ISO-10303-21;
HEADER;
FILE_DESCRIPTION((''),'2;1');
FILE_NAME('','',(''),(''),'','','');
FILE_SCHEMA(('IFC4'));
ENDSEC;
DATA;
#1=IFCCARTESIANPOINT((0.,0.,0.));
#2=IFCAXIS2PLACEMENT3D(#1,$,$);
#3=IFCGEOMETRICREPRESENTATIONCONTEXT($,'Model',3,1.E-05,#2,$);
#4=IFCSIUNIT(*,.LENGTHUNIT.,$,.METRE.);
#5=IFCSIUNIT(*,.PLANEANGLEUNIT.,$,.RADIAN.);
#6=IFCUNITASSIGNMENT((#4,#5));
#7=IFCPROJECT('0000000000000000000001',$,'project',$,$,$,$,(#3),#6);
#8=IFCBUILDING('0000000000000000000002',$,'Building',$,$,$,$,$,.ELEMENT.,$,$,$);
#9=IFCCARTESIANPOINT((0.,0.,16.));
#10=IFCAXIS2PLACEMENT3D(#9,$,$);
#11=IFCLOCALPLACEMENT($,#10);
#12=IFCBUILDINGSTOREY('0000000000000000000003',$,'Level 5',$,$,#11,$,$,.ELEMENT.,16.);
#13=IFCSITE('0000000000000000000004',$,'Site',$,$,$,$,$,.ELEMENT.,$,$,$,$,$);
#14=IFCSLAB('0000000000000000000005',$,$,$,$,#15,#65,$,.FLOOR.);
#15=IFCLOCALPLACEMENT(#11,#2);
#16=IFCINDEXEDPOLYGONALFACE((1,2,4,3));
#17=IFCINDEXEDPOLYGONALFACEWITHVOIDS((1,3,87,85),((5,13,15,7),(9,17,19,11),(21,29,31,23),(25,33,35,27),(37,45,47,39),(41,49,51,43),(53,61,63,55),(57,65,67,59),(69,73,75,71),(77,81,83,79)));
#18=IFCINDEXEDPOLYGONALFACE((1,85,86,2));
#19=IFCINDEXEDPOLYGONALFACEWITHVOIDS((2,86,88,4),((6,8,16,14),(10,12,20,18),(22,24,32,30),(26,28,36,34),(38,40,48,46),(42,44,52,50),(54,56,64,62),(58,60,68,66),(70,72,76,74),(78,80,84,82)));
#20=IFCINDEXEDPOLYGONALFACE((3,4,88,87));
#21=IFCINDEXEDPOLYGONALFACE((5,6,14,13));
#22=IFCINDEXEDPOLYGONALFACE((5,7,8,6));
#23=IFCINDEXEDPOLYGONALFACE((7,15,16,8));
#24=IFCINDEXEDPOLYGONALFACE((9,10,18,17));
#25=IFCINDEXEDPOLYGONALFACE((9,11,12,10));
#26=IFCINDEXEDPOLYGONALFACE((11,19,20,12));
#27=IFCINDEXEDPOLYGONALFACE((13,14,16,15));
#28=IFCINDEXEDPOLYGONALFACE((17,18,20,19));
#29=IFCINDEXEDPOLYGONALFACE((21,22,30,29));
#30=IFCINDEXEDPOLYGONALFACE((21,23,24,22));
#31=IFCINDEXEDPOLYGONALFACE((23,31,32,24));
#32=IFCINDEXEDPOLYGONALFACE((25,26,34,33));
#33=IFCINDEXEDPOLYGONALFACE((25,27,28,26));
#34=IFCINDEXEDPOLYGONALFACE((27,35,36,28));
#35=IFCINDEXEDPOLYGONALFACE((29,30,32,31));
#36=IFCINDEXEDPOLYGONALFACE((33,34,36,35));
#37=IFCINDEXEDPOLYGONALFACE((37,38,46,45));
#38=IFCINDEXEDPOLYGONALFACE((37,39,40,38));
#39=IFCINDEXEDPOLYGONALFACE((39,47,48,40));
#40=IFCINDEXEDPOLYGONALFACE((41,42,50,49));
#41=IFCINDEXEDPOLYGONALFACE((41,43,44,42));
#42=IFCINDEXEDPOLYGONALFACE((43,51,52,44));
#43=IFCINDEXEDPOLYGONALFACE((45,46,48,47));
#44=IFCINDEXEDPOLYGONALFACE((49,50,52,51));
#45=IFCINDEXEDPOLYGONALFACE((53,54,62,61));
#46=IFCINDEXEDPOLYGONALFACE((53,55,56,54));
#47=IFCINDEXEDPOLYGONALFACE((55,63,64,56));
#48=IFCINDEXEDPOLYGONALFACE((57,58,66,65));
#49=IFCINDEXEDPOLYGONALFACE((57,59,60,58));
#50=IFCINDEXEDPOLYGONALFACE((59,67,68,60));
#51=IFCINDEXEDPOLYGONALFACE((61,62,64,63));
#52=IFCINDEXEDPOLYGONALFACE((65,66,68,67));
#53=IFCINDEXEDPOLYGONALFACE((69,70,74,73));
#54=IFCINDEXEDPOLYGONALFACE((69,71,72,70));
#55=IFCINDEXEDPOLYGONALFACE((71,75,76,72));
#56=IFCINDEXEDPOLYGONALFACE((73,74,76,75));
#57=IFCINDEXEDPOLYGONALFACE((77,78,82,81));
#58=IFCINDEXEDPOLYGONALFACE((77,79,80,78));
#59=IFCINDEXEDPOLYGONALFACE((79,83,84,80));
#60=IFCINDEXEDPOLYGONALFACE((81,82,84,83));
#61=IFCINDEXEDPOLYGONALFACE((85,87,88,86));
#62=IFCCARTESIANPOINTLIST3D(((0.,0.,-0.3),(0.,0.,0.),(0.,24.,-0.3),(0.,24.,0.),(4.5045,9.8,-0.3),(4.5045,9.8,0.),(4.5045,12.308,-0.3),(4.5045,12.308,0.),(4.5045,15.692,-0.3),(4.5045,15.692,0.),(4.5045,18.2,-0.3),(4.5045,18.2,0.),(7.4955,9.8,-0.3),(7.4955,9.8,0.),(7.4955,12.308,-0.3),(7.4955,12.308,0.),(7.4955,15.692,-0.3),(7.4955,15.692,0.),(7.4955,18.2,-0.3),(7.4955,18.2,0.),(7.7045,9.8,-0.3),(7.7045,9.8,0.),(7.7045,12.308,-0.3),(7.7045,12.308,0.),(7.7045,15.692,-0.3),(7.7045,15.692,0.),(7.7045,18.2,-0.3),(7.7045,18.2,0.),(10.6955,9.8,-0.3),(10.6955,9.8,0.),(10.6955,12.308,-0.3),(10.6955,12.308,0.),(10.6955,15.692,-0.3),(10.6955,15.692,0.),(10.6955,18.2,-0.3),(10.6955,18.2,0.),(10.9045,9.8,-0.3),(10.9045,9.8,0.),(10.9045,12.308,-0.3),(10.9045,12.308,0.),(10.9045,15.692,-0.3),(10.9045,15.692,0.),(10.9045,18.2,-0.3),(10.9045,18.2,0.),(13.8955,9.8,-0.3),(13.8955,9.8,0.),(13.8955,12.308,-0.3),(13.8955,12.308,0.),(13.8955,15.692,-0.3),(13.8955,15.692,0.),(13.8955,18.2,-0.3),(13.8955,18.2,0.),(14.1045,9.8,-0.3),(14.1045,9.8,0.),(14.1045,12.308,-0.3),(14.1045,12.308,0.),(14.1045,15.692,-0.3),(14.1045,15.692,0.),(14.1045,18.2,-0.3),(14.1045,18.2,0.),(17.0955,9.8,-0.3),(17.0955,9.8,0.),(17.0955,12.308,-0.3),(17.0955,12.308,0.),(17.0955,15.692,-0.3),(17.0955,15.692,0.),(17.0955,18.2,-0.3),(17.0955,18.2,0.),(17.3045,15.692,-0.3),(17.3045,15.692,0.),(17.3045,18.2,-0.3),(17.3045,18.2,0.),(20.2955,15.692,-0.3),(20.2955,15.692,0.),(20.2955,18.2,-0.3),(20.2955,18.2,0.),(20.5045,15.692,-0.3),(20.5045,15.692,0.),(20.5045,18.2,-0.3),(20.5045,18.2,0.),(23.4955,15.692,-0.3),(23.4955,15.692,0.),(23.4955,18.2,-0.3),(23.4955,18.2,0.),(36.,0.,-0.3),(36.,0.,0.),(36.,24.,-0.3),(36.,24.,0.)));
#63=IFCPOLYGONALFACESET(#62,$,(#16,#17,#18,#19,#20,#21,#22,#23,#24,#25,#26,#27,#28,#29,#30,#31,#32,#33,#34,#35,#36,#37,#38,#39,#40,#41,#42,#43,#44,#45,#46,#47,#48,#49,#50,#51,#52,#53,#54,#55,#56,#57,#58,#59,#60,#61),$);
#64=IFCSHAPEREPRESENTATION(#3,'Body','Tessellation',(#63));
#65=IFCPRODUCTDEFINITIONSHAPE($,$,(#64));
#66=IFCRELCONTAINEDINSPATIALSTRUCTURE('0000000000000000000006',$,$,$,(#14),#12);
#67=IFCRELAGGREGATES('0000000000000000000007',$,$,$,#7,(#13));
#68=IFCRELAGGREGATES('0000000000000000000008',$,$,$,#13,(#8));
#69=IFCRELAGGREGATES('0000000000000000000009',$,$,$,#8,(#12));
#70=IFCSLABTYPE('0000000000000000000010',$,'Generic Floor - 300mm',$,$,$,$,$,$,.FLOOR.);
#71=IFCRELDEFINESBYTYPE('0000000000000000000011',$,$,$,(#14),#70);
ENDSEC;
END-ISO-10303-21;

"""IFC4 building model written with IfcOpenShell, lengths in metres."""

from ifc_helpers import new_model, si_unit, frame, origin, place, context, project, spatial, polyline, outline, extrude, type_object, element, save


model = new_model("IFC4")

# Units and contexts
model_context = context("Model", 3, precision=1e-05, world=origin())
ifc_project = project(units=[si_unit("LENGTHUNIT", "METRE"), si_unit("PLANEANGLEUNIT", "RADIAN")], contexts=[model_context])

# Site, building, storey
site = spatial("IfcSite", under=ifc_project, Name="Site", CompositionType="ELEMENT")
building = spatial("IfcBuilding", under=site, Name="Building", CompositionType="ELEMENT")
storey_placement = place(None, frame((0.0, 0.0, 16.0)))
storey = spatial("IfcBuildingStorey", under=building, at=storey_placement, Name="Level 5", CompositionType="ELEMENT", Elevation=16.0)

# Slab, openings
slab_type = type_object("IfcSlabType", Name="Generic Floor - 300mm", PredefinedType="FLOOR")
slab_placement = place(None, frame((0.0, 0.0, 16.0)))
slab = element("IfcSlab", 1, at=slab_placement, inside=storey, type_object=slab_type, PredefinedType="FLOOR", context=model_context, shape_type="SweptSolid", body=[
    extrude(outline(polyline([(0.0, 0.0), (36.0, 0.0), (36.0, 24.0), (0.0, 24.0), (0.0, 0.0)])), origin(), (0.0, 0.0, -1.0), 0.3),
])
opening_1_placement = place(None, frame((0.0, 0.0, 16.001)))
element("IfcOpeningElement", 2, at=opening_1_placement, cuts=slab, PredefinedType="OPENING", context=model_context, shape_type="SweptSolid", body=[
    extrude(outline(polyline([(4.5045, 9.8), (7.4955, 9.8), (7.4955, 12.308), (4.5045, 12.308), (4.5045, 9.8)])), origin(), (0.0, 0.0, -1.0), 0.302),
])
opening_2_placement = place(None, frame((0.0, 0.0, 16.001)))
element("IfcOpeningElement", 3, at=opening_2_placement, cuts=slab, PredefinedType="OPENING", context=model_context, shape_type="SweptSolid", body=[
    extrude(outline(polyline([(7.7045, 9.8), (10.6955, 9.8), (10.6955, 12.308), (7.7045, 12.308), (7.7045, 9.8)])), origin(), (0.0, 0.0, -1.0), 0.302),
])
opening_3_placement = place(None, frame((0.0, 0.0, 16.001)))
element("IfcOpeningElement", 4, at=opening_3_placement, cuts=slab, PredefinedType="OPENING", context=model_context, shape_type="SweptSolid", body=[
    extrude(outline(polyline([(10.9045, 9.8), (13.8955, 9.8), (13.8955, 12.308), (10.9045, 12.308), (10.9045, 9.8)])), origin(), (0.0, 0.0, -1.0), 0.302),
])
opening_4_placement = place(None, frame((0.0, 0.0, 16.001)))
element("IfcOpeningElement", 5, at=opening_4_placement, cuts=slab, PredefinedType="OPENING", context=model_context, shape_type="SweptSolid", body=[
    extrude(outline(polyline([(14.1045, 9.8), (17.0955, 9.8), (17.0955, 12.308), (14.1045, 12.308), (14.1045, 9.8)])), origin(), (0.0, 0.0, -1.0), 0.302),
])
opening_5_placement = place(None, frame((0.0, 0.0, 16.001)))
element("IfcOpeningElement", 6, at=opening_5_placement, cuts=slab, PredefinedType="OPENING", context=model_context, shape_type="SweptSolid", body=[
    extrude(outline(polyline([(7.4955, 18.2), (4.5045, 18.2), (4.5045, 15.692), (7.4955, 15.692), (7.4955, 18.2)])), origin(), (0.0, 0.0, -1.0), 0.302),
])
opening_6_placement = place(None, frame((0.0, 0.0, 16.001)))
element("IfcOpeningElement", 7, at=opening_6_placement, cuts=slab, PredefinedType="OPENING", context=model_context, shape_type="SweptSolid", body=[
    extrude(outline(polyline([(10.6955, 18.2), (7.7045, 18.2), (7.7045, 15.692), (10.6955, 15.692), (10.6955, 18.2)])), origin(), (0.0, 0.0, -1.0), 0.302),
])
opening_7_placement = place(None, frame((0.0, 0.0, 16.001)))
element("IfcOpeningElement", 8, at=opening_7_placement, cuts=slab, PredefinedType="OPENING", context=model_context, shape_type="SweptSolid", body=[
    extrude(outline(polyline([(13.8955, 18.2), (10.9045, 18.2), (10.9045, 15.692), (13.8955, 15.692), (13.8955, 18.2)])), origin(), (0.0, 0.0, -1.0), 0.302),
])
opening_8_placement = place(None, frame((0.0, 0.0, 16.001)))
element("IfcOpeningElement", 9, at=opening_8_placement, cuts=slab, PredefinedType="OPENING", context=model_context, shape_type="SweptSolid", body=[
    extrude(outline(polyline([(17.0955, 18.2), (14.1045, 18.2), (14.1045, 15.692), (17.0955, 15.692), (17.0955, 18.2)])), origin(), (0.0, 0.0, -1.0), 0.302),
])
opening_9_placement = place(None, frame((0.0, 0.0, 16.001)))
element("IfcOpeningElement", 10, at=opening_9_placement, cuts=slab, PredefinedType="OPENING", context=model_context, shape_type="SweptSolid", body=[
    extrude(outline(polyline([(20.2955, 18.2), (17.3045, 18.2), (17.3045, 15.692), (20.2955, 15.692), (20.2955, 18.2)])), origin(), (0.0, 0.0, -1.0), 0.302),
])
opening_10_placement = place(None, frame((0.0, 0.0, 16.001)))
element("IfcOpeningElement", 11, at=opening_10_placement, cuts=slab, PredefinedType="OPENING", context=model_context, shape_type="SweptSolid", body=[
    extrude(outline(polyline([(23.4955, 18.2), (20.5045, 18.2), (20.5045, 15.692), (23.4955, 15.692), (23.4955, 18.2)])), origin(), (0.0, 0.0, -1.0), 0.302),
])

save(model, "model.ifc")
